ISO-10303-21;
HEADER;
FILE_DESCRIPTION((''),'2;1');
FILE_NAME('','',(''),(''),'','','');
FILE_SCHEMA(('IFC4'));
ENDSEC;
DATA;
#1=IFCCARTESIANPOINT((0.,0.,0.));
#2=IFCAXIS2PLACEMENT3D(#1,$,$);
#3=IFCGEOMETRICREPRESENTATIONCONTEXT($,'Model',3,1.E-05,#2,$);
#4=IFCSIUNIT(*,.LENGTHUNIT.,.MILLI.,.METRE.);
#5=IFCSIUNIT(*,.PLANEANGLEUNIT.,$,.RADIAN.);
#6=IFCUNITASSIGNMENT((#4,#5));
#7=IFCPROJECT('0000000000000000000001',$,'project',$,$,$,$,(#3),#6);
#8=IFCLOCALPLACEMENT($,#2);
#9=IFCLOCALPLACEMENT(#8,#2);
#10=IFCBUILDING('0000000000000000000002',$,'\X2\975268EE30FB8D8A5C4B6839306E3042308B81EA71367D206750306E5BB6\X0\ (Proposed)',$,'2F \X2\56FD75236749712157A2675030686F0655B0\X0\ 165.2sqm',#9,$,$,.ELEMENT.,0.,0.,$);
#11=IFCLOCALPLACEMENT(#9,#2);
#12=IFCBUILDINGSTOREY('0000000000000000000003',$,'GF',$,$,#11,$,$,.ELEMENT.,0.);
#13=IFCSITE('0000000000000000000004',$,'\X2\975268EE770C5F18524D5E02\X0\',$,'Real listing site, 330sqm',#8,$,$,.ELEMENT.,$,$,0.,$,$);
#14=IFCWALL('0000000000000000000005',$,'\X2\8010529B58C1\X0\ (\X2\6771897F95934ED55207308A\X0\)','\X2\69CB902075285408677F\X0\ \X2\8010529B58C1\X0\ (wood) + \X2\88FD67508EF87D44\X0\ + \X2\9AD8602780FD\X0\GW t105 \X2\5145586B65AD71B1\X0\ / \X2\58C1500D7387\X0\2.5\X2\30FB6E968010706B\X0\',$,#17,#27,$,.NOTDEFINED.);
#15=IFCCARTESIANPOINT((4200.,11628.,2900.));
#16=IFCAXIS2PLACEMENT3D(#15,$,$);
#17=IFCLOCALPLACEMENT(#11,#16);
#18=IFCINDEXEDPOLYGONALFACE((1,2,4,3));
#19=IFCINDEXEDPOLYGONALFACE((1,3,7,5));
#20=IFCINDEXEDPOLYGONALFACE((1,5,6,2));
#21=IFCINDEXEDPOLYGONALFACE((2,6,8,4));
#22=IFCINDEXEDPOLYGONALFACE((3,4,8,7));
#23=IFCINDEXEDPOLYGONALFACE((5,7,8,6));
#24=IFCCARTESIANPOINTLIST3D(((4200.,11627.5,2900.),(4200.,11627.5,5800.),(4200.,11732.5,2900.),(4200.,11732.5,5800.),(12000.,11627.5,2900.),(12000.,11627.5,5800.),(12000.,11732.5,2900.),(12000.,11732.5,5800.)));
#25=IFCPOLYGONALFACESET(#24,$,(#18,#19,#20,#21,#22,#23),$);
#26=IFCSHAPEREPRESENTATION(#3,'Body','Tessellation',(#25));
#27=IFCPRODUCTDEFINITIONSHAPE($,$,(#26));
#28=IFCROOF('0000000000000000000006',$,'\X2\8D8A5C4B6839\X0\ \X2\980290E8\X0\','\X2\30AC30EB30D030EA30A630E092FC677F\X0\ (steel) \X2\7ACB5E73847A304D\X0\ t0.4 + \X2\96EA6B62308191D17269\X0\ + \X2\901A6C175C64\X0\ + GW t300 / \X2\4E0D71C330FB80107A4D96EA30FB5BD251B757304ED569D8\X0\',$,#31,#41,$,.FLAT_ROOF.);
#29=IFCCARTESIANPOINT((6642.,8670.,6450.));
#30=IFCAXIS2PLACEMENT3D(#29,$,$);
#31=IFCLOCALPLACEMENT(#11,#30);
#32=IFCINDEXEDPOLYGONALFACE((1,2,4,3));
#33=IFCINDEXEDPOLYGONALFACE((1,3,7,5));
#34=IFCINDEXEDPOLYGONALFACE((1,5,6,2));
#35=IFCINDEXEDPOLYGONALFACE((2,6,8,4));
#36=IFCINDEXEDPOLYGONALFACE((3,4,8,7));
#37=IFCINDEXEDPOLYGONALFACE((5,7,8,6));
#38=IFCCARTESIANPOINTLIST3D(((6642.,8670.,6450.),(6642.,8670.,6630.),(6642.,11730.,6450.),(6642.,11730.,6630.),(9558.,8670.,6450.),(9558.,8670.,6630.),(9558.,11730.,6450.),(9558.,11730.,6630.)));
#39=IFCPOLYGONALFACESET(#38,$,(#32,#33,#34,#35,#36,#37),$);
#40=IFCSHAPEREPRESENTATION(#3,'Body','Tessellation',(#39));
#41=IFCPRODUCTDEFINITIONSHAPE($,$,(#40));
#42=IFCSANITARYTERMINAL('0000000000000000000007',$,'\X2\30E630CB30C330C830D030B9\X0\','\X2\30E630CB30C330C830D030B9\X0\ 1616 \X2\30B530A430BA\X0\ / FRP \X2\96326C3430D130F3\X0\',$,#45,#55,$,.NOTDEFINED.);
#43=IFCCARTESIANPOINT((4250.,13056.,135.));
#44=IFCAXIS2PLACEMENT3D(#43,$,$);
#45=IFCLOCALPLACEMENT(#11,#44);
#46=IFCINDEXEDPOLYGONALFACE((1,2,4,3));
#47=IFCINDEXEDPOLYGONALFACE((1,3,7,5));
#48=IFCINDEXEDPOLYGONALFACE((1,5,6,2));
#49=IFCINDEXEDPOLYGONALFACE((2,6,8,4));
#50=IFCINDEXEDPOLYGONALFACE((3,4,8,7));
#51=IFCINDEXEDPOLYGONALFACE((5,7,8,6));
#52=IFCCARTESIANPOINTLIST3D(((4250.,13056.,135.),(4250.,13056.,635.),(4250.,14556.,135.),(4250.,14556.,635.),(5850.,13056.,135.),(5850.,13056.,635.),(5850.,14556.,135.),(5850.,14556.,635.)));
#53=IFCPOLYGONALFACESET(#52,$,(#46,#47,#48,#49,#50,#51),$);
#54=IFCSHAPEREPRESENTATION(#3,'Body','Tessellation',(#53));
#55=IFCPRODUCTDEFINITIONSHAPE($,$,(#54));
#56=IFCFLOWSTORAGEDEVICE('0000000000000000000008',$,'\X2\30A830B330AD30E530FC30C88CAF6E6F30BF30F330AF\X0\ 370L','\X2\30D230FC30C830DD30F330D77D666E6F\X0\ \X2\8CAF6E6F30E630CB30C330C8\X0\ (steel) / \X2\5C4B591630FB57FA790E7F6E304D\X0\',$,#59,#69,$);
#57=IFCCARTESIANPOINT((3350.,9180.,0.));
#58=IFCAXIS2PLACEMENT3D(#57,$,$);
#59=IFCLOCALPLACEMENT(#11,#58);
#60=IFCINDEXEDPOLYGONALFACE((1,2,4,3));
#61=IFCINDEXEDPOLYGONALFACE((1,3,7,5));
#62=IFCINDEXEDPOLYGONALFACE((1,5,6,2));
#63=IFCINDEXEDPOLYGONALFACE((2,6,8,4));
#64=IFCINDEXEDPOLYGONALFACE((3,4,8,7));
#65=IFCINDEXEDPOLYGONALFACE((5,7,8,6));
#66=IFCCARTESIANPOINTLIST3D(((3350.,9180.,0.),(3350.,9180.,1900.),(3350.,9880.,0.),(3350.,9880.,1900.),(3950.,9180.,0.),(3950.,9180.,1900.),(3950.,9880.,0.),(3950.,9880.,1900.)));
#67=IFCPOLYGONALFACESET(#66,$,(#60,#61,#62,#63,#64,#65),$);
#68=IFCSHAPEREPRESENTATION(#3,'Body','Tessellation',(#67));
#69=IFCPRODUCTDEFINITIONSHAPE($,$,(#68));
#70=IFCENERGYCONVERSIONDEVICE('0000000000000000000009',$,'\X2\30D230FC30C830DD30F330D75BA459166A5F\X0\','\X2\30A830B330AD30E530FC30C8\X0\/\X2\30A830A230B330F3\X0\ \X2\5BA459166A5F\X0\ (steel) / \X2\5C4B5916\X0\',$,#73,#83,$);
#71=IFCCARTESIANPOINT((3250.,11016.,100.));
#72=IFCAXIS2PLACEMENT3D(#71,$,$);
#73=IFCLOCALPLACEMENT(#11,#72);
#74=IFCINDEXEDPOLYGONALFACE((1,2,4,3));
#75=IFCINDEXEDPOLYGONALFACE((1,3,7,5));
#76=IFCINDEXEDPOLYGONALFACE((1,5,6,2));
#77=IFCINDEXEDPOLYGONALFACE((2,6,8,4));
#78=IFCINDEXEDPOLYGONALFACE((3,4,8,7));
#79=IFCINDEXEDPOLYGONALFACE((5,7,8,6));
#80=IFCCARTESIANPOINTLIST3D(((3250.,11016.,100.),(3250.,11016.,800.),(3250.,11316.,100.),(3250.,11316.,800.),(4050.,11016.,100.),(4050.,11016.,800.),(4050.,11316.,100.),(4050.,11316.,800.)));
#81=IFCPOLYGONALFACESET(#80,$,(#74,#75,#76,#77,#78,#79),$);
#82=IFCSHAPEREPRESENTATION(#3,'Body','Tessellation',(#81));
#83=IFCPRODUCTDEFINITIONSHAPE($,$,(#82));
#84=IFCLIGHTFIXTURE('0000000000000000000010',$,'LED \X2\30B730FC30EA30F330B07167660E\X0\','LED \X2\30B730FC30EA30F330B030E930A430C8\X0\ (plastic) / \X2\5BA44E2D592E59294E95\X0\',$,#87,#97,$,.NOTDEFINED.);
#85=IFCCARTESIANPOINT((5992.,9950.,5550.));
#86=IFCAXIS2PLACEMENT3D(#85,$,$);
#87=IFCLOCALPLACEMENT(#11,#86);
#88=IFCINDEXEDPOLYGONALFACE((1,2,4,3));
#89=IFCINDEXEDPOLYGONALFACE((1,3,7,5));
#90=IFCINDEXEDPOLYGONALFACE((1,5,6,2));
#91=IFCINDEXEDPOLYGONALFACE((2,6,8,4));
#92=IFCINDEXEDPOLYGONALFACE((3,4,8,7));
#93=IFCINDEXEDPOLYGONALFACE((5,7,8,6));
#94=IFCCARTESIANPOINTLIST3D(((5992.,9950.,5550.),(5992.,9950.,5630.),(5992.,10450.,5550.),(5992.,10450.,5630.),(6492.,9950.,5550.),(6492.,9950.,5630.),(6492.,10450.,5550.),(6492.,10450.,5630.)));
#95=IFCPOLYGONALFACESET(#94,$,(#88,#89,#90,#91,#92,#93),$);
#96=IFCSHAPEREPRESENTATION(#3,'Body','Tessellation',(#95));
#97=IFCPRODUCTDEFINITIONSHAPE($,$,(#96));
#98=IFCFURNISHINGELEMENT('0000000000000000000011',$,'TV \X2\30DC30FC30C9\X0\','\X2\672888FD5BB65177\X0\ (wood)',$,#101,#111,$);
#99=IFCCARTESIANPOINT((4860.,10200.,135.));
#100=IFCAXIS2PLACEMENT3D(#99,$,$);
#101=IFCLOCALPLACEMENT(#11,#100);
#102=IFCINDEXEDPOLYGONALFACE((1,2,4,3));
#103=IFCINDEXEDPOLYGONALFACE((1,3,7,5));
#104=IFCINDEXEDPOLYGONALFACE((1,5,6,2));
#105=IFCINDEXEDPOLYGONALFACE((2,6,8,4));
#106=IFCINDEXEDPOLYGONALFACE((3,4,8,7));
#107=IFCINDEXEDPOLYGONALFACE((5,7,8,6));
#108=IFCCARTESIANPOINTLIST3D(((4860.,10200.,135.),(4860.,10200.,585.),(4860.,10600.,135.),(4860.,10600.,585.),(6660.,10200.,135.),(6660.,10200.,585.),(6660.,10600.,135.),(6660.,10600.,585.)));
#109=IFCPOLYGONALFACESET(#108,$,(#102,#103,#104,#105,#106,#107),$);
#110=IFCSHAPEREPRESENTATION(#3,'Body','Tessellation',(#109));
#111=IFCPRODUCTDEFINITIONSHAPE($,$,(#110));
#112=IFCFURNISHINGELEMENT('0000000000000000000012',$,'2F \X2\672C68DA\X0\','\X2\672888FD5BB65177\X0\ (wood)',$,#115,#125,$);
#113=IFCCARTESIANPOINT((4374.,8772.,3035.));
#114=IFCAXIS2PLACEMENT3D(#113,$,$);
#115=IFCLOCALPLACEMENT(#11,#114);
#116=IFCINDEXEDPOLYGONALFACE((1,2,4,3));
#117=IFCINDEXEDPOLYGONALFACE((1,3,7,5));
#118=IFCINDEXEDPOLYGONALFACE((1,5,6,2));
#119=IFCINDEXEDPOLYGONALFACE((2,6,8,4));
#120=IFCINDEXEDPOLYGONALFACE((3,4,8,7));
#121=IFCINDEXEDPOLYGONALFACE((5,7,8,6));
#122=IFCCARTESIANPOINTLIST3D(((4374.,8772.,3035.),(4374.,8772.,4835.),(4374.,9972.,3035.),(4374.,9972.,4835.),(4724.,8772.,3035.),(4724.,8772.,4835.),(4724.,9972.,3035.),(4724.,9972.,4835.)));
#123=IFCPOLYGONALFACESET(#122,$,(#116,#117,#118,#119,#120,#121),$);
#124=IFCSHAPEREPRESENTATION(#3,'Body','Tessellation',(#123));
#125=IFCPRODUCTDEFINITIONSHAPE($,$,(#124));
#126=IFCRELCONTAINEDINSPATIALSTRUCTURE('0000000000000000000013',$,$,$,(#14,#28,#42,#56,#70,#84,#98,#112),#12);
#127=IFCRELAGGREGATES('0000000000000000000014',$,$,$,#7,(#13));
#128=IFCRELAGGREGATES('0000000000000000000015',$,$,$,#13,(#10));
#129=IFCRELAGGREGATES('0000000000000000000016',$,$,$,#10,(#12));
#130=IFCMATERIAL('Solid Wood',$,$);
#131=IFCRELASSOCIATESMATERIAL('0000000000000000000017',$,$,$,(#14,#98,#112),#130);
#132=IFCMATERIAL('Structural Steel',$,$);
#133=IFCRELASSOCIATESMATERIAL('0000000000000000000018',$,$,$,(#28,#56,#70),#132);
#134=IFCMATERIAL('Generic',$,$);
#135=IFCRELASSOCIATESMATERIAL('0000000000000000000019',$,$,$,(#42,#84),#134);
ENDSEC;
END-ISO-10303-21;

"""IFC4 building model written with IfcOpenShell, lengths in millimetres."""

from ifc_helpers import new_model, si_unit, frame, frame_2d, origin, place, context, project, spatial, rectangle, extrude, material, element, save


model = new_model("IFC4")

# Units and contexts
model_context = context("Model", 3, precision=1e-05, world=origin())
ifc_project = project(units=[si_unit("LENGTHUNIT", "METRE", prefix="MILLI"), si_unit("PLANEANGLEUNIT", "RADIAN")], contexts=[model_context])

# Site, building, storey
site_placement = place(None, origin())
site = spatial("IfcSite", under=ifc_project, at=site_placement, Name="青森県弘前市", ObjectType="Real listing site, 330sqm", CompositionType="ELEMENT", RefElevation=0.0)
building_placement = place(site_placement, origin())
building = spatial("IfcBuilding", under=site, at=building_placement, Name="青森・越屋根のある自然素材の家 (Proposed)", ObjectType="2F 国産杉無垢材と漆喰 165.2sqm", CompositionType="ELEMENT", ElevationOfRefHeight=0.0, ElevationOfTerrain=0.0)
storey_placement = place(building_placement, origin())
storey = spatial("IfcBuildingStorey", under=building, at=storey_placement, Name="GF", CompositionType="ELEMENT", Elevation=0.0)

# Shared definitions
ifc_material_1 = material(Name="Solid Wood")

# Wall
wall_1_placement = place(storey_placement, frame((4200.0, 11628.0, 2900.0)))
element("IfcWall", 1, at=wall_1_placement, inside=storey, material=ifc_material_1, Name="耐力壁 (東西間仕切り)", Description="構造用合板 耐力壁 (wood) + 製材軸組 + 高性能GW t105 充填断熱 / 壁倍率2.5・準耐火", PredefinedType="NOTDEFINED", context=model_context, shape_type="SweptSolid", body=[
    extrude(rectangle(XDim=7800.0, YDim=105.0, at=frame_2d((3900.0, 52.0))), frame((4200.0, 11628.0, 2900.0)), (0.0, 0.0, 1.0), 2900.0),
])

# Roof
ifc_material_2 = material(Name="Structural Steel")
roof_placement = place(storey_placement, frame((6642.0, 8670.0, 6450.0)))
element("IfcRoof", 2, at=roof_placement, inside=storey, material=ifc_material_2, Name="越屋根 頂部", Description="ガルバリウム鋼板 (steel) 立平葺き t0.4 + 雪止め金物 + 通気層 + GW t300 / 不燃・耐積雪・寒冷地仕様", PredefinedType="FLAT_ROOF", context=model_context, shape_type="SweptSolid", body=[
    extrude(rectangle(XDim=2916.0, YDim=3060.0, at=frame_2d((1458.0, 1530.0))), frame((6642.0, 8670.0, 6450.0)), (0.0, 0.0, 1.0), 180.0),
])

# Sanitary terminal
ifc_material_3 = material(Name="Generic")
sanitary_terminal_placement = place(storey_placement, frame((4250.0, 13056.0, 135.0)))
element("IfcSanitaryTerminal", 3, at=sanitary_terminal_placement, inside=storey, material=ifc_material_3, Name="ユニットバス", Description="ユニットバス 1616 サイズ / FRP 防水パン", PredefinedType="NOTDEFINED", context=model_context, shape_type="SweptSolid", body=[
    extrude(rectangle(XDim=1600.0, YDim=1500.0, at=frame_2d((800.0, 750.0))), frame((4250.0, 13056.0, 135.0)), (0.0, 0.0, 1.0), 500.0),
])

# Flow storage device
flow_storage_device_placement = place(storey_placement, frame((3350.0, 9180.0, 0.0)))
element("IfcFlowStorageDevice", 4, at=flow_storage_device_placement, inside=storey, material=ifc_material_2, Name="エコキュート貯湯タンク 370L", Description="ヒートポンプ給湯 貯湯ユニット (steel) / 屋外・基礎置き", context=model_context, shape_type="SweptSolid", body=[
    extrude(rectangle(XDim=600.0, YDim=700.0, at=frame_2d((300.0, 350.0))), frame((3350.0, 9180.0, 0.0)), (0.0, 0.0, 1.0), 1900.0),
])

# Energy conversion device
energy_conversion_device_placement = place(storey_placement, frame((3250.0, 11016.0, 100.0)))
element("IfcEnergyConversionDevice", 5, at=energy_conversion_device_placement, inside=storey, material=ifc_material_2, Name="ヒートポンプ室外機", Description="エコキュート/エアコン 室外機 (steel) / 屋外", context=model_context, shape_type="SweptSolid", body=[
    extrude(rectangle(XDim=800.0, YDim=300.0, at=frame_2d((400.0, 150.0))), frame((3250.0, 11016.0, 100.0)), (0.0, 0.0, 1.0), 700.0),
])

# Light fixture
light_fixture_placement = place(storey_placement, frame((5992.0, 9950.0, 5550.0)))
element("IfcLightFixture", 6, at=light_fixture_placement, inside=storey, material=ifc_material_3, Name="LED シーリング照明", Description="LED シーリングライト (plastic) / 室中央天井", PredefinedType="NOTDEFINED", context=model_context, shape_type="SweptSolid", body=[
    extrude(rectangle(XDim=500.0, YDim=500.0, at=frame_2d((250.0, 250.0))), frame((5992.0, 9950.0, 5550.0)), (0.0, 0.0, 1.0), 80.0),
])

# Furnishing elements
furnishing_1_placement = place(storey_placement, frame((4860.0, 10200.0, 135.0)))
element("IfcFurnishingElement", 7, at=furnishing_1_placement, inside=storey, material=ifc_material_1, Name="TV ボード", Description="木製家具 (wood)", context=model_context, shape_type="SweptSolid", body=[
    extrude(rectangle(XDim=1800.0, YDim=400.0, at=frame_2d((900.0, 200.0))), frame((4860.0, 10200.0, 135.0)), (0.0, 0.0, 1.0), 450.0),
])
furnishing_2_placement = place(storey_placement, frame((4374.0, 8772.0, 3035.0)))
element("IfcFurnishingElement", 8, at=furnishing_2_placement, inside=storey, material=ifc_material_1, Name="2F 本棚", Description="木製家具 (wood)", context=model_context, shape_type="SweptSolid", body=[
    extrude(rectangle(XDim=350.0, YDim=1200.0, at=frame_2d((175.0, 600.0))), frame((4374.0, 8772.0, 3035.0)), (0.0, 0.0, 1.0), 1800.0),
])

save(model, "model.ifc")
